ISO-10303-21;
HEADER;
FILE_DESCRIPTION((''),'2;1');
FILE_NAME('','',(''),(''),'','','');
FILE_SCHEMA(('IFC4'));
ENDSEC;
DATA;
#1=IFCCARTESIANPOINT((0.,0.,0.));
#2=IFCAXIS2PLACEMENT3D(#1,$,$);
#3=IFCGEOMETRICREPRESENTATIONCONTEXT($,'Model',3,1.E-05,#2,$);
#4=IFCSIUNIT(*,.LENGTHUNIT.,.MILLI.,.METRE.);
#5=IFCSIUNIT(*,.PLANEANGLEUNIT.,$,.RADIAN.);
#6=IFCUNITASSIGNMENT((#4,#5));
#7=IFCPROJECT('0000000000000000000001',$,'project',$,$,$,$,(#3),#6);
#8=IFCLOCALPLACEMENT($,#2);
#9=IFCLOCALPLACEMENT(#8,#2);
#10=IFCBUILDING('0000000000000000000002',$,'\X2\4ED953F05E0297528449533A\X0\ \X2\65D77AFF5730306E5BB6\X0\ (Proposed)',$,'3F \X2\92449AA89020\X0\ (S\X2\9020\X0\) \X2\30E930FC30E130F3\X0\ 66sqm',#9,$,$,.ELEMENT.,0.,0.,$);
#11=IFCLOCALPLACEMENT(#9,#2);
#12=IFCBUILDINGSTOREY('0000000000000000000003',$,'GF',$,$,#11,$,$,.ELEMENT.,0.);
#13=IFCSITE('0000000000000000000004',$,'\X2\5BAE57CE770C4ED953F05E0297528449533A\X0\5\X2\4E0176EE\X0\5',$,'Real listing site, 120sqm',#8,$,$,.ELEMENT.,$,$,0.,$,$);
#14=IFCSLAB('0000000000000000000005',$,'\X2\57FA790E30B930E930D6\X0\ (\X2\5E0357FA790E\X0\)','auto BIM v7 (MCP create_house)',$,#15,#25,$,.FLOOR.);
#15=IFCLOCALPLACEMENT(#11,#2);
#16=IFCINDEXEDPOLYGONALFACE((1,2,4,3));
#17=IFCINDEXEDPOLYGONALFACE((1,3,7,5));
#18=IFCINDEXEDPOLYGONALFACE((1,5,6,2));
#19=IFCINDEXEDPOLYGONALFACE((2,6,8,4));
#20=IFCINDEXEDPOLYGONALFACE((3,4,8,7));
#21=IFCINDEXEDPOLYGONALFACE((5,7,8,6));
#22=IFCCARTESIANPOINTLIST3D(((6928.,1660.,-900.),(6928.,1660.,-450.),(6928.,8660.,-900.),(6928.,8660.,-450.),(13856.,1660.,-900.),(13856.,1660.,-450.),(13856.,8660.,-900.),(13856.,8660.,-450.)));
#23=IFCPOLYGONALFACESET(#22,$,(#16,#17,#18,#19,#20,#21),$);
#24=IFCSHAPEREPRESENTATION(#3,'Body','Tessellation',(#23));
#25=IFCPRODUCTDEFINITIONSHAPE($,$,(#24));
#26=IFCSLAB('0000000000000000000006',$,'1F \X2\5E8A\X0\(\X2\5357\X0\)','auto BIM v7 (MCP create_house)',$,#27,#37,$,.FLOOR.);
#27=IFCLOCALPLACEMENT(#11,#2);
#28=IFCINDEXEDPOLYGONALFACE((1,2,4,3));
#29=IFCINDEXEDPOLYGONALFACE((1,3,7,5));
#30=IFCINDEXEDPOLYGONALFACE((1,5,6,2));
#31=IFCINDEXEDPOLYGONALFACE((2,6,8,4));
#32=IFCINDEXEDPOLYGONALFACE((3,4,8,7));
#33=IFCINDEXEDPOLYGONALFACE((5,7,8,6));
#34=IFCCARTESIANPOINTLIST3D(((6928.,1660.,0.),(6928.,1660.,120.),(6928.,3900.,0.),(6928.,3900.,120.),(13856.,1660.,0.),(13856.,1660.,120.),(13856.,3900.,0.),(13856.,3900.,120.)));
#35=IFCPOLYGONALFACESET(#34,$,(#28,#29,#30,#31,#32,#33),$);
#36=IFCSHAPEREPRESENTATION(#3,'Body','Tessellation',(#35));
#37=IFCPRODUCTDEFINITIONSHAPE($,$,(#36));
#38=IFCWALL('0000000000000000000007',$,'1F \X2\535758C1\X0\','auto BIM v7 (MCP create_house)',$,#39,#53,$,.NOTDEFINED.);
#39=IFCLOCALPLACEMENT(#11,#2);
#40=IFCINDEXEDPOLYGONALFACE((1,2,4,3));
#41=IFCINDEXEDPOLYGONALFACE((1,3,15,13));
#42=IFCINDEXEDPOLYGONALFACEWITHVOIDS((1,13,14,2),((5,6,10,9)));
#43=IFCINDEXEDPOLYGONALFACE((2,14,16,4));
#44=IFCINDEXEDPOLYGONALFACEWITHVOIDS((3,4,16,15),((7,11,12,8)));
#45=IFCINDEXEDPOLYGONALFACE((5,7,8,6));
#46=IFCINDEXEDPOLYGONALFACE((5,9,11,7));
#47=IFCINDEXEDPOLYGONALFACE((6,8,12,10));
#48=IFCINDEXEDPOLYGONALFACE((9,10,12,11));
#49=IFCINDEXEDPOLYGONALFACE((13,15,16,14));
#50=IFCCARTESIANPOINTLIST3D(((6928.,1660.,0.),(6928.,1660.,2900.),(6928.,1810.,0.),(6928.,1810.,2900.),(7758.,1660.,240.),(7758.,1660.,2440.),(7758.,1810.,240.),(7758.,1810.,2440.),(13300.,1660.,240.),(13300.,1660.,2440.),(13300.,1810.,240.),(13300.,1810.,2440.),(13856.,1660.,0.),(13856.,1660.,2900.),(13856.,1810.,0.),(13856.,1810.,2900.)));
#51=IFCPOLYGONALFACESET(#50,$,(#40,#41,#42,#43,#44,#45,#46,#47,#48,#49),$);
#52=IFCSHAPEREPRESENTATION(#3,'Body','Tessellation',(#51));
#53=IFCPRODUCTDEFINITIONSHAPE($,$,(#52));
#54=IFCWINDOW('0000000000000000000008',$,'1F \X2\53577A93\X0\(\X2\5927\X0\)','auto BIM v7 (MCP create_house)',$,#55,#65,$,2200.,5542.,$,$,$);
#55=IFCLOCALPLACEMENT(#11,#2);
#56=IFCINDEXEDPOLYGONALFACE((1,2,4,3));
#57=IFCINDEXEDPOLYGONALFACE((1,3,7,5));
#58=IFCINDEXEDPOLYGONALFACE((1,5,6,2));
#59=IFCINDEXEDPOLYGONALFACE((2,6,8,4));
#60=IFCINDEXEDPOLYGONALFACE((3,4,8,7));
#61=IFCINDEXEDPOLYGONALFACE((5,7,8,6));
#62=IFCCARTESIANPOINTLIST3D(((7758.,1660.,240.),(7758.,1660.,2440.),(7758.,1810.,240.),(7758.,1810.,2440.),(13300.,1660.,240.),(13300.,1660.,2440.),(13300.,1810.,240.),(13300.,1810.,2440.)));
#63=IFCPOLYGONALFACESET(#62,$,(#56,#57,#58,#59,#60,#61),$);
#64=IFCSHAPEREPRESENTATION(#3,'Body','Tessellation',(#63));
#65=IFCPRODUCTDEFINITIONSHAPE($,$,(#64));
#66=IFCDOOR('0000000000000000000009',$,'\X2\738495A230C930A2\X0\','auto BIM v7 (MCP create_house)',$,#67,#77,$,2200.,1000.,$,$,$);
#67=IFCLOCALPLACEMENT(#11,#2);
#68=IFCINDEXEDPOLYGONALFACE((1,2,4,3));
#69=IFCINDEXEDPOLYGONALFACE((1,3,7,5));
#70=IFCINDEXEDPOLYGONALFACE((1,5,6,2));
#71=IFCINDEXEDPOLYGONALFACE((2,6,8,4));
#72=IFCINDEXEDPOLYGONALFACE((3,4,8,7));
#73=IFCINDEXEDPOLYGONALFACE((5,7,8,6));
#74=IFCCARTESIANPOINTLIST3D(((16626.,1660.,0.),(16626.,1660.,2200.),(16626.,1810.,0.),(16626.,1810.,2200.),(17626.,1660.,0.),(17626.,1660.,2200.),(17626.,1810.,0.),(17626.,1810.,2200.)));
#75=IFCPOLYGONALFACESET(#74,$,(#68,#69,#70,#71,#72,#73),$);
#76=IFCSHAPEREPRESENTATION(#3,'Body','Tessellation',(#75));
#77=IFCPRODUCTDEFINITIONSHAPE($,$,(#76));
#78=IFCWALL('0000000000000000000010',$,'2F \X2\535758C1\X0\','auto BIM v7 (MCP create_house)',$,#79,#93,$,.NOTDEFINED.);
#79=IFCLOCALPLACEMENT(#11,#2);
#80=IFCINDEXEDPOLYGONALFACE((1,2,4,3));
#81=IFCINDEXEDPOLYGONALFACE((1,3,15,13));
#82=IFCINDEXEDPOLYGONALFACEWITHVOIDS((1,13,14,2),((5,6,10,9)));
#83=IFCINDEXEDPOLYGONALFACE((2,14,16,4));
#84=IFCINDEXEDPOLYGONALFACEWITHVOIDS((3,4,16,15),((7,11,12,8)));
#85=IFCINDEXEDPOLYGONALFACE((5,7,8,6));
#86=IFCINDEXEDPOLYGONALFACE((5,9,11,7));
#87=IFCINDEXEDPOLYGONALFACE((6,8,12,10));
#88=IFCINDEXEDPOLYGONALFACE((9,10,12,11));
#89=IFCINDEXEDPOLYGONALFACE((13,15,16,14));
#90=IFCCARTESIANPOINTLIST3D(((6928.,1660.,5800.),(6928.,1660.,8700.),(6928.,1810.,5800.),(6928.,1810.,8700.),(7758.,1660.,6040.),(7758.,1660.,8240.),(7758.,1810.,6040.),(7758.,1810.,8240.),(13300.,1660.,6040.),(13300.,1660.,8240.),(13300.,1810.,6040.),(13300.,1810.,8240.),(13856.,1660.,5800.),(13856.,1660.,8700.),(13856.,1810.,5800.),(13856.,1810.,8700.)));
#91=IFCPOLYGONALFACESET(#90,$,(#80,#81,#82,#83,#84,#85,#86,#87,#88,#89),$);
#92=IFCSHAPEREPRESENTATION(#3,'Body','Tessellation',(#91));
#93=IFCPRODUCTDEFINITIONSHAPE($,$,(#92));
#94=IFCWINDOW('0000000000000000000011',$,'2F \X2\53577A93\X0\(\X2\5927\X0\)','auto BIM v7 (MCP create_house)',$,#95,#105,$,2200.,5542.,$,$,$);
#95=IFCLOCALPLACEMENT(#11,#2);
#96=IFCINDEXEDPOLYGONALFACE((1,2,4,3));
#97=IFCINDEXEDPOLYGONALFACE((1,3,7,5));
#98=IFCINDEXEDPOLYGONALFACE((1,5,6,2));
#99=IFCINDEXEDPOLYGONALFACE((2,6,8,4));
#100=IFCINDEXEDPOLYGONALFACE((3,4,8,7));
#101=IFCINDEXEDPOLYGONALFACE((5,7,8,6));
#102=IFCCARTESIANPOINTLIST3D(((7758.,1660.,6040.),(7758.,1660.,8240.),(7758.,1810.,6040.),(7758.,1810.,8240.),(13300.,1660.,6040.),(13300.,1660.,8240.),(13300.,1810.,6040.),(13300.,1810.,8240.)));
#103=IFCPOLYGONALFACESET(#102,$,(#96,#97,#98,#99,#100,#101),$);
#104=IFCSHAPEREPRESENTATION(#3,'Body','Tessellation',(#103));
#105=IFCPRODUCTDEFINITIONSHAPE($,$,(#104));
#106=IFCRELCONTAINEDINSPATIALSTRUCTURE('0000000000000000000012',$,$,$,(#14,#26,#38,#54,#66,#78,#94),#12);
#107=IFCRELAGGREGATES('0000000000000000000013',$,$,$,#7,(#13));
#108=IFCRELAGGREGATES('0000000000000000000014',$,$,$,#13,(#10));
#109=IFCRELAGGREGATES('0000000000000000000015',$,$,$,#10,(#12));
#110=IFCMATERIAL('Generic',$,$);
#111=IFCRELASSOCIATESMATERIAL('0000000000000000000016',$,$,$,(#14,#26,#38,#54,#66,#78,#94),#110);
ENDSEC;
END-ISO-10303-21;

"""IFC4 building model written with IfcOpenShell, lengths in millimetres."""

from ifc_helpers import new_model, si_unit, frame, frame_2d, origin, place, context, project, spatial, rectangle, extrude, material, element, fill, save


model = new_model("IFC4")

# Units and contexts
model_context = context("Model", 3, precision=1e-05, world=origin())
ifc_project = project(units=[si_unit("LENGTHUNIT", "METRE", prefix="MILLI"), si_unit("PLANEANGLEUNIT", "RADIAN")], contexts=[model_context])

# Site, building, storey
site_placement = place(None, origin())
site = spatial("IfcSite", under=ifc_project, at=site_placement, Name="宮城県仙台市青葉区5丁目5", ObjectType="Real listing site, 120sqm", CompositionType="ELEMENT", RefElevation=0.0)
building_placement = place(site_placement, origin())
building = spatial("IfcBuilding", under=site, at=building_placement, Name="仙台市青葉区 旗竿地の家 (Proposed)", ObjectType="3F 鉄骨造 (S造) ラーメン 66sqm", CompositionType="ELEMENT", ElevationOfRefHeight=0.0, ElevationOfTerrain=0.0)
storey_placement = place(building_placement, origin())
storey = spatial("IfcBuildingStorey", under=building, at=storey_placement, Name="GF", CompositionType="ELEMENT", Elevation=0.0)

# Slabs
ifc_material = material(Name="Generic")
slab_1_placement = place(storey_placement, frame((3464.0, 830.0, -450.0)))
element("IfcSlab", 1, at=slab_1_placement, inside=storey, material=ifc_material, Name="基礎スラブ (布基礎)", Description="auto BIM v7 (MCP create_house)", PredefinedType="FLOOR", context=model_context, shape_type="SweptSolid", body=[
    extrude(rectangle(XDim=6928.0, YDim=7000.0, at=frame_2d((3464.0, 3500.0))), frame((3464.0, 830.0, -450.0)), (0.0, 0.0, 1.0), 450.0),
])
slab_2_placement = place(storey_placement, frame((3464.0, 830.0, 0.0)))
element("IfcSlab", 2, at=slab_2_placement, inside=storey, material=ifc_material, Name="1F 床(南)", Description="auto BIM v7 (MCP create_house)", PredefinedType="FLOOR", context=model_context, shape_type="SweptSolid", body=[
    extrude(rectangle(XDim=6928.0, YDim=2240.0, at=frame_2d((3464.0, 1120.0))), frame((3464.0, 830.0, 0.0)), (0.0, 0.0, 1.0), 120.0),
])

# Wall, openings, window, door
wall_1_placement = place(storey_placement, frame((3464.0, 830.0, 0.0)))
wall_1 = element("IfcWall", 3, at=wall_1_placement, inside=storey, material=ifc_material, Name="1F 南壁", Description="auto BIM v7 (MCP create_house)", PredefinedType="NOTDEFINED", context=model_context, shape_type="SweptSolid", body=[
    extrude(rectangle(XDim=6928.0, YDim=150.0, at=frame_2d((3464.0, 75.0))), frame((3464.0, 830.0, 0.0)), (0.0, 0.0, 1.0), 2900.0),
])
opening_1_placement = place(storey_placement, frame((3879.0, 830.0, 120.0)))
opening_1 = element("IfcOpeningElement", 4, at=opening_1_placement, cuts=wall_1, PredefinedType="NOTDEFINED", context=model_context, shape_type="SweptSolid", body=[
    extrude(rectangle(XDim=5542.0, YDim=150.0, at=frame_2d((2771.0, 75.0))), frame((3879.0, 830.0, 120.0)), (0.0, 0.0, 1.0), 2200.0),
])
opening_2_placement = place(storey_placement, frame((8313.0, 830.0, 0.0)))
opening_2 = element("IfcOpeningElement", 5, at=opening_2_placement, cuts=wall_1, PredefinedType="NOTDEFINED", context=model_context, shape_type="SweptSolid", body=[
    extrude(rectangle(XDim=1000.0, YDim=150.0, at=frame_2d((500.0, 75.0))), frame((8313.0, 830.0, 0.0)), (0.0, 0.0, 1.0), 2200.0),
])
window_1_placement = place(storey_placement, frame((3879.0, 830.0, 120.0)))
window_1 = element("IfcWindow", 6, at=window_1_placement, inside=storey, material=ifc_material, Name="1F 南窓(大)", Description="auto BIM v7 (MCP create_house)", OverallHeight=2200.0, OverallWidth=5542.0, context=model_context, shape_type="SweptSolid", body=[
    extrude(rectangle(XDim=5542.0, YDim=150.0, at=frame_2d((2771.0, 75.0))), frame((3879.0, 830.0, 120.0)), (0.0, 0.0, 1.0), 2200.0),
])
fill(opening_1, window_1)
door_placement = place(storey_placement, frame((8313.0, 830.0, 0.0)))
door = element("IfcDoor", 7, at=door_placement, inside=storey, material=ifc_material, Name="玄関ドア", Description="auto BIM v7 (MCP create_house)", OverallHeight=2200.0, OverallWidth=1000.0, context=model_context, shape_type="SweptSolid", body=[
    extrude(rectangle(XDim=1000.0, YDim=150.0, at=frame_2d((500.0, 75.0))), frame((8313.0, 830.0, 0.0)), (0.0, 0.0, 1.0), 2200.0),
])
fill(opening_2, door)

# Wall, opening, window
wall_2_placement = place(storey_placement, frame((3464.0, 830.0, 2900.0)))
wall_2 = element("IfcWall", 8, at=wall_2_placement, inside=storey, material=ifc_material, Name="2F 南壁", Description="auto BIM v7 (MCP create_house)", PredefinedType="NOTDEFINED", context=model_context, shape_type="SweptSolid", body=[
    extrude(rectangle(XDim=6928.0, YDim=150.0, at=frame_2d((3464.0, 75.0))), frame((3464.0, 830.0, 2900.0)), (0.0, 0.0, 1.0), 2900.0),
])
opening_3_placement = place(storey_placement, frame((3879.0, 830.0, 3020.0)))
opening_3 = element("IfcOpeningElement", 9, at=opening_3_placement, cuts=wall_2, PredefinedType="NOTDEFINED", context=model_context, shape_type="SweptSolid", body=[
    extrude(rectangle(XDim=5542.0, YDim=150.0, at=frame_2d((2771.0, 75.0))), frame((3879.0, 830.0, 3020.0)), (0.0, 0.0, 1.0), 2200.0),
])
window_2_placement = place(storey_placement, frame((3879.0, 830.0, 3020.0)))
window_2 = element("IfcWindow", 10, at=window_2_placement, inside=storey, material=ifc_material, Name="2F 南窓(大)", Description="auto BIM v7 (MCP create_house)", OverallHeight=2200.0, OverallWidth=5542.0, context=model_context, shape_type="SweptSolid", body=[
    extrude(rectangle(XDim=5542.0, YDim=150.0, at=frame_2d((2771.0, 75.0))), frame((3879.0, 830.0, 3020.0)), (0.0, 0.0, 1.0), 2200.0),
])
fill(opening_3, window_2)

save(model, "model.ifc")
